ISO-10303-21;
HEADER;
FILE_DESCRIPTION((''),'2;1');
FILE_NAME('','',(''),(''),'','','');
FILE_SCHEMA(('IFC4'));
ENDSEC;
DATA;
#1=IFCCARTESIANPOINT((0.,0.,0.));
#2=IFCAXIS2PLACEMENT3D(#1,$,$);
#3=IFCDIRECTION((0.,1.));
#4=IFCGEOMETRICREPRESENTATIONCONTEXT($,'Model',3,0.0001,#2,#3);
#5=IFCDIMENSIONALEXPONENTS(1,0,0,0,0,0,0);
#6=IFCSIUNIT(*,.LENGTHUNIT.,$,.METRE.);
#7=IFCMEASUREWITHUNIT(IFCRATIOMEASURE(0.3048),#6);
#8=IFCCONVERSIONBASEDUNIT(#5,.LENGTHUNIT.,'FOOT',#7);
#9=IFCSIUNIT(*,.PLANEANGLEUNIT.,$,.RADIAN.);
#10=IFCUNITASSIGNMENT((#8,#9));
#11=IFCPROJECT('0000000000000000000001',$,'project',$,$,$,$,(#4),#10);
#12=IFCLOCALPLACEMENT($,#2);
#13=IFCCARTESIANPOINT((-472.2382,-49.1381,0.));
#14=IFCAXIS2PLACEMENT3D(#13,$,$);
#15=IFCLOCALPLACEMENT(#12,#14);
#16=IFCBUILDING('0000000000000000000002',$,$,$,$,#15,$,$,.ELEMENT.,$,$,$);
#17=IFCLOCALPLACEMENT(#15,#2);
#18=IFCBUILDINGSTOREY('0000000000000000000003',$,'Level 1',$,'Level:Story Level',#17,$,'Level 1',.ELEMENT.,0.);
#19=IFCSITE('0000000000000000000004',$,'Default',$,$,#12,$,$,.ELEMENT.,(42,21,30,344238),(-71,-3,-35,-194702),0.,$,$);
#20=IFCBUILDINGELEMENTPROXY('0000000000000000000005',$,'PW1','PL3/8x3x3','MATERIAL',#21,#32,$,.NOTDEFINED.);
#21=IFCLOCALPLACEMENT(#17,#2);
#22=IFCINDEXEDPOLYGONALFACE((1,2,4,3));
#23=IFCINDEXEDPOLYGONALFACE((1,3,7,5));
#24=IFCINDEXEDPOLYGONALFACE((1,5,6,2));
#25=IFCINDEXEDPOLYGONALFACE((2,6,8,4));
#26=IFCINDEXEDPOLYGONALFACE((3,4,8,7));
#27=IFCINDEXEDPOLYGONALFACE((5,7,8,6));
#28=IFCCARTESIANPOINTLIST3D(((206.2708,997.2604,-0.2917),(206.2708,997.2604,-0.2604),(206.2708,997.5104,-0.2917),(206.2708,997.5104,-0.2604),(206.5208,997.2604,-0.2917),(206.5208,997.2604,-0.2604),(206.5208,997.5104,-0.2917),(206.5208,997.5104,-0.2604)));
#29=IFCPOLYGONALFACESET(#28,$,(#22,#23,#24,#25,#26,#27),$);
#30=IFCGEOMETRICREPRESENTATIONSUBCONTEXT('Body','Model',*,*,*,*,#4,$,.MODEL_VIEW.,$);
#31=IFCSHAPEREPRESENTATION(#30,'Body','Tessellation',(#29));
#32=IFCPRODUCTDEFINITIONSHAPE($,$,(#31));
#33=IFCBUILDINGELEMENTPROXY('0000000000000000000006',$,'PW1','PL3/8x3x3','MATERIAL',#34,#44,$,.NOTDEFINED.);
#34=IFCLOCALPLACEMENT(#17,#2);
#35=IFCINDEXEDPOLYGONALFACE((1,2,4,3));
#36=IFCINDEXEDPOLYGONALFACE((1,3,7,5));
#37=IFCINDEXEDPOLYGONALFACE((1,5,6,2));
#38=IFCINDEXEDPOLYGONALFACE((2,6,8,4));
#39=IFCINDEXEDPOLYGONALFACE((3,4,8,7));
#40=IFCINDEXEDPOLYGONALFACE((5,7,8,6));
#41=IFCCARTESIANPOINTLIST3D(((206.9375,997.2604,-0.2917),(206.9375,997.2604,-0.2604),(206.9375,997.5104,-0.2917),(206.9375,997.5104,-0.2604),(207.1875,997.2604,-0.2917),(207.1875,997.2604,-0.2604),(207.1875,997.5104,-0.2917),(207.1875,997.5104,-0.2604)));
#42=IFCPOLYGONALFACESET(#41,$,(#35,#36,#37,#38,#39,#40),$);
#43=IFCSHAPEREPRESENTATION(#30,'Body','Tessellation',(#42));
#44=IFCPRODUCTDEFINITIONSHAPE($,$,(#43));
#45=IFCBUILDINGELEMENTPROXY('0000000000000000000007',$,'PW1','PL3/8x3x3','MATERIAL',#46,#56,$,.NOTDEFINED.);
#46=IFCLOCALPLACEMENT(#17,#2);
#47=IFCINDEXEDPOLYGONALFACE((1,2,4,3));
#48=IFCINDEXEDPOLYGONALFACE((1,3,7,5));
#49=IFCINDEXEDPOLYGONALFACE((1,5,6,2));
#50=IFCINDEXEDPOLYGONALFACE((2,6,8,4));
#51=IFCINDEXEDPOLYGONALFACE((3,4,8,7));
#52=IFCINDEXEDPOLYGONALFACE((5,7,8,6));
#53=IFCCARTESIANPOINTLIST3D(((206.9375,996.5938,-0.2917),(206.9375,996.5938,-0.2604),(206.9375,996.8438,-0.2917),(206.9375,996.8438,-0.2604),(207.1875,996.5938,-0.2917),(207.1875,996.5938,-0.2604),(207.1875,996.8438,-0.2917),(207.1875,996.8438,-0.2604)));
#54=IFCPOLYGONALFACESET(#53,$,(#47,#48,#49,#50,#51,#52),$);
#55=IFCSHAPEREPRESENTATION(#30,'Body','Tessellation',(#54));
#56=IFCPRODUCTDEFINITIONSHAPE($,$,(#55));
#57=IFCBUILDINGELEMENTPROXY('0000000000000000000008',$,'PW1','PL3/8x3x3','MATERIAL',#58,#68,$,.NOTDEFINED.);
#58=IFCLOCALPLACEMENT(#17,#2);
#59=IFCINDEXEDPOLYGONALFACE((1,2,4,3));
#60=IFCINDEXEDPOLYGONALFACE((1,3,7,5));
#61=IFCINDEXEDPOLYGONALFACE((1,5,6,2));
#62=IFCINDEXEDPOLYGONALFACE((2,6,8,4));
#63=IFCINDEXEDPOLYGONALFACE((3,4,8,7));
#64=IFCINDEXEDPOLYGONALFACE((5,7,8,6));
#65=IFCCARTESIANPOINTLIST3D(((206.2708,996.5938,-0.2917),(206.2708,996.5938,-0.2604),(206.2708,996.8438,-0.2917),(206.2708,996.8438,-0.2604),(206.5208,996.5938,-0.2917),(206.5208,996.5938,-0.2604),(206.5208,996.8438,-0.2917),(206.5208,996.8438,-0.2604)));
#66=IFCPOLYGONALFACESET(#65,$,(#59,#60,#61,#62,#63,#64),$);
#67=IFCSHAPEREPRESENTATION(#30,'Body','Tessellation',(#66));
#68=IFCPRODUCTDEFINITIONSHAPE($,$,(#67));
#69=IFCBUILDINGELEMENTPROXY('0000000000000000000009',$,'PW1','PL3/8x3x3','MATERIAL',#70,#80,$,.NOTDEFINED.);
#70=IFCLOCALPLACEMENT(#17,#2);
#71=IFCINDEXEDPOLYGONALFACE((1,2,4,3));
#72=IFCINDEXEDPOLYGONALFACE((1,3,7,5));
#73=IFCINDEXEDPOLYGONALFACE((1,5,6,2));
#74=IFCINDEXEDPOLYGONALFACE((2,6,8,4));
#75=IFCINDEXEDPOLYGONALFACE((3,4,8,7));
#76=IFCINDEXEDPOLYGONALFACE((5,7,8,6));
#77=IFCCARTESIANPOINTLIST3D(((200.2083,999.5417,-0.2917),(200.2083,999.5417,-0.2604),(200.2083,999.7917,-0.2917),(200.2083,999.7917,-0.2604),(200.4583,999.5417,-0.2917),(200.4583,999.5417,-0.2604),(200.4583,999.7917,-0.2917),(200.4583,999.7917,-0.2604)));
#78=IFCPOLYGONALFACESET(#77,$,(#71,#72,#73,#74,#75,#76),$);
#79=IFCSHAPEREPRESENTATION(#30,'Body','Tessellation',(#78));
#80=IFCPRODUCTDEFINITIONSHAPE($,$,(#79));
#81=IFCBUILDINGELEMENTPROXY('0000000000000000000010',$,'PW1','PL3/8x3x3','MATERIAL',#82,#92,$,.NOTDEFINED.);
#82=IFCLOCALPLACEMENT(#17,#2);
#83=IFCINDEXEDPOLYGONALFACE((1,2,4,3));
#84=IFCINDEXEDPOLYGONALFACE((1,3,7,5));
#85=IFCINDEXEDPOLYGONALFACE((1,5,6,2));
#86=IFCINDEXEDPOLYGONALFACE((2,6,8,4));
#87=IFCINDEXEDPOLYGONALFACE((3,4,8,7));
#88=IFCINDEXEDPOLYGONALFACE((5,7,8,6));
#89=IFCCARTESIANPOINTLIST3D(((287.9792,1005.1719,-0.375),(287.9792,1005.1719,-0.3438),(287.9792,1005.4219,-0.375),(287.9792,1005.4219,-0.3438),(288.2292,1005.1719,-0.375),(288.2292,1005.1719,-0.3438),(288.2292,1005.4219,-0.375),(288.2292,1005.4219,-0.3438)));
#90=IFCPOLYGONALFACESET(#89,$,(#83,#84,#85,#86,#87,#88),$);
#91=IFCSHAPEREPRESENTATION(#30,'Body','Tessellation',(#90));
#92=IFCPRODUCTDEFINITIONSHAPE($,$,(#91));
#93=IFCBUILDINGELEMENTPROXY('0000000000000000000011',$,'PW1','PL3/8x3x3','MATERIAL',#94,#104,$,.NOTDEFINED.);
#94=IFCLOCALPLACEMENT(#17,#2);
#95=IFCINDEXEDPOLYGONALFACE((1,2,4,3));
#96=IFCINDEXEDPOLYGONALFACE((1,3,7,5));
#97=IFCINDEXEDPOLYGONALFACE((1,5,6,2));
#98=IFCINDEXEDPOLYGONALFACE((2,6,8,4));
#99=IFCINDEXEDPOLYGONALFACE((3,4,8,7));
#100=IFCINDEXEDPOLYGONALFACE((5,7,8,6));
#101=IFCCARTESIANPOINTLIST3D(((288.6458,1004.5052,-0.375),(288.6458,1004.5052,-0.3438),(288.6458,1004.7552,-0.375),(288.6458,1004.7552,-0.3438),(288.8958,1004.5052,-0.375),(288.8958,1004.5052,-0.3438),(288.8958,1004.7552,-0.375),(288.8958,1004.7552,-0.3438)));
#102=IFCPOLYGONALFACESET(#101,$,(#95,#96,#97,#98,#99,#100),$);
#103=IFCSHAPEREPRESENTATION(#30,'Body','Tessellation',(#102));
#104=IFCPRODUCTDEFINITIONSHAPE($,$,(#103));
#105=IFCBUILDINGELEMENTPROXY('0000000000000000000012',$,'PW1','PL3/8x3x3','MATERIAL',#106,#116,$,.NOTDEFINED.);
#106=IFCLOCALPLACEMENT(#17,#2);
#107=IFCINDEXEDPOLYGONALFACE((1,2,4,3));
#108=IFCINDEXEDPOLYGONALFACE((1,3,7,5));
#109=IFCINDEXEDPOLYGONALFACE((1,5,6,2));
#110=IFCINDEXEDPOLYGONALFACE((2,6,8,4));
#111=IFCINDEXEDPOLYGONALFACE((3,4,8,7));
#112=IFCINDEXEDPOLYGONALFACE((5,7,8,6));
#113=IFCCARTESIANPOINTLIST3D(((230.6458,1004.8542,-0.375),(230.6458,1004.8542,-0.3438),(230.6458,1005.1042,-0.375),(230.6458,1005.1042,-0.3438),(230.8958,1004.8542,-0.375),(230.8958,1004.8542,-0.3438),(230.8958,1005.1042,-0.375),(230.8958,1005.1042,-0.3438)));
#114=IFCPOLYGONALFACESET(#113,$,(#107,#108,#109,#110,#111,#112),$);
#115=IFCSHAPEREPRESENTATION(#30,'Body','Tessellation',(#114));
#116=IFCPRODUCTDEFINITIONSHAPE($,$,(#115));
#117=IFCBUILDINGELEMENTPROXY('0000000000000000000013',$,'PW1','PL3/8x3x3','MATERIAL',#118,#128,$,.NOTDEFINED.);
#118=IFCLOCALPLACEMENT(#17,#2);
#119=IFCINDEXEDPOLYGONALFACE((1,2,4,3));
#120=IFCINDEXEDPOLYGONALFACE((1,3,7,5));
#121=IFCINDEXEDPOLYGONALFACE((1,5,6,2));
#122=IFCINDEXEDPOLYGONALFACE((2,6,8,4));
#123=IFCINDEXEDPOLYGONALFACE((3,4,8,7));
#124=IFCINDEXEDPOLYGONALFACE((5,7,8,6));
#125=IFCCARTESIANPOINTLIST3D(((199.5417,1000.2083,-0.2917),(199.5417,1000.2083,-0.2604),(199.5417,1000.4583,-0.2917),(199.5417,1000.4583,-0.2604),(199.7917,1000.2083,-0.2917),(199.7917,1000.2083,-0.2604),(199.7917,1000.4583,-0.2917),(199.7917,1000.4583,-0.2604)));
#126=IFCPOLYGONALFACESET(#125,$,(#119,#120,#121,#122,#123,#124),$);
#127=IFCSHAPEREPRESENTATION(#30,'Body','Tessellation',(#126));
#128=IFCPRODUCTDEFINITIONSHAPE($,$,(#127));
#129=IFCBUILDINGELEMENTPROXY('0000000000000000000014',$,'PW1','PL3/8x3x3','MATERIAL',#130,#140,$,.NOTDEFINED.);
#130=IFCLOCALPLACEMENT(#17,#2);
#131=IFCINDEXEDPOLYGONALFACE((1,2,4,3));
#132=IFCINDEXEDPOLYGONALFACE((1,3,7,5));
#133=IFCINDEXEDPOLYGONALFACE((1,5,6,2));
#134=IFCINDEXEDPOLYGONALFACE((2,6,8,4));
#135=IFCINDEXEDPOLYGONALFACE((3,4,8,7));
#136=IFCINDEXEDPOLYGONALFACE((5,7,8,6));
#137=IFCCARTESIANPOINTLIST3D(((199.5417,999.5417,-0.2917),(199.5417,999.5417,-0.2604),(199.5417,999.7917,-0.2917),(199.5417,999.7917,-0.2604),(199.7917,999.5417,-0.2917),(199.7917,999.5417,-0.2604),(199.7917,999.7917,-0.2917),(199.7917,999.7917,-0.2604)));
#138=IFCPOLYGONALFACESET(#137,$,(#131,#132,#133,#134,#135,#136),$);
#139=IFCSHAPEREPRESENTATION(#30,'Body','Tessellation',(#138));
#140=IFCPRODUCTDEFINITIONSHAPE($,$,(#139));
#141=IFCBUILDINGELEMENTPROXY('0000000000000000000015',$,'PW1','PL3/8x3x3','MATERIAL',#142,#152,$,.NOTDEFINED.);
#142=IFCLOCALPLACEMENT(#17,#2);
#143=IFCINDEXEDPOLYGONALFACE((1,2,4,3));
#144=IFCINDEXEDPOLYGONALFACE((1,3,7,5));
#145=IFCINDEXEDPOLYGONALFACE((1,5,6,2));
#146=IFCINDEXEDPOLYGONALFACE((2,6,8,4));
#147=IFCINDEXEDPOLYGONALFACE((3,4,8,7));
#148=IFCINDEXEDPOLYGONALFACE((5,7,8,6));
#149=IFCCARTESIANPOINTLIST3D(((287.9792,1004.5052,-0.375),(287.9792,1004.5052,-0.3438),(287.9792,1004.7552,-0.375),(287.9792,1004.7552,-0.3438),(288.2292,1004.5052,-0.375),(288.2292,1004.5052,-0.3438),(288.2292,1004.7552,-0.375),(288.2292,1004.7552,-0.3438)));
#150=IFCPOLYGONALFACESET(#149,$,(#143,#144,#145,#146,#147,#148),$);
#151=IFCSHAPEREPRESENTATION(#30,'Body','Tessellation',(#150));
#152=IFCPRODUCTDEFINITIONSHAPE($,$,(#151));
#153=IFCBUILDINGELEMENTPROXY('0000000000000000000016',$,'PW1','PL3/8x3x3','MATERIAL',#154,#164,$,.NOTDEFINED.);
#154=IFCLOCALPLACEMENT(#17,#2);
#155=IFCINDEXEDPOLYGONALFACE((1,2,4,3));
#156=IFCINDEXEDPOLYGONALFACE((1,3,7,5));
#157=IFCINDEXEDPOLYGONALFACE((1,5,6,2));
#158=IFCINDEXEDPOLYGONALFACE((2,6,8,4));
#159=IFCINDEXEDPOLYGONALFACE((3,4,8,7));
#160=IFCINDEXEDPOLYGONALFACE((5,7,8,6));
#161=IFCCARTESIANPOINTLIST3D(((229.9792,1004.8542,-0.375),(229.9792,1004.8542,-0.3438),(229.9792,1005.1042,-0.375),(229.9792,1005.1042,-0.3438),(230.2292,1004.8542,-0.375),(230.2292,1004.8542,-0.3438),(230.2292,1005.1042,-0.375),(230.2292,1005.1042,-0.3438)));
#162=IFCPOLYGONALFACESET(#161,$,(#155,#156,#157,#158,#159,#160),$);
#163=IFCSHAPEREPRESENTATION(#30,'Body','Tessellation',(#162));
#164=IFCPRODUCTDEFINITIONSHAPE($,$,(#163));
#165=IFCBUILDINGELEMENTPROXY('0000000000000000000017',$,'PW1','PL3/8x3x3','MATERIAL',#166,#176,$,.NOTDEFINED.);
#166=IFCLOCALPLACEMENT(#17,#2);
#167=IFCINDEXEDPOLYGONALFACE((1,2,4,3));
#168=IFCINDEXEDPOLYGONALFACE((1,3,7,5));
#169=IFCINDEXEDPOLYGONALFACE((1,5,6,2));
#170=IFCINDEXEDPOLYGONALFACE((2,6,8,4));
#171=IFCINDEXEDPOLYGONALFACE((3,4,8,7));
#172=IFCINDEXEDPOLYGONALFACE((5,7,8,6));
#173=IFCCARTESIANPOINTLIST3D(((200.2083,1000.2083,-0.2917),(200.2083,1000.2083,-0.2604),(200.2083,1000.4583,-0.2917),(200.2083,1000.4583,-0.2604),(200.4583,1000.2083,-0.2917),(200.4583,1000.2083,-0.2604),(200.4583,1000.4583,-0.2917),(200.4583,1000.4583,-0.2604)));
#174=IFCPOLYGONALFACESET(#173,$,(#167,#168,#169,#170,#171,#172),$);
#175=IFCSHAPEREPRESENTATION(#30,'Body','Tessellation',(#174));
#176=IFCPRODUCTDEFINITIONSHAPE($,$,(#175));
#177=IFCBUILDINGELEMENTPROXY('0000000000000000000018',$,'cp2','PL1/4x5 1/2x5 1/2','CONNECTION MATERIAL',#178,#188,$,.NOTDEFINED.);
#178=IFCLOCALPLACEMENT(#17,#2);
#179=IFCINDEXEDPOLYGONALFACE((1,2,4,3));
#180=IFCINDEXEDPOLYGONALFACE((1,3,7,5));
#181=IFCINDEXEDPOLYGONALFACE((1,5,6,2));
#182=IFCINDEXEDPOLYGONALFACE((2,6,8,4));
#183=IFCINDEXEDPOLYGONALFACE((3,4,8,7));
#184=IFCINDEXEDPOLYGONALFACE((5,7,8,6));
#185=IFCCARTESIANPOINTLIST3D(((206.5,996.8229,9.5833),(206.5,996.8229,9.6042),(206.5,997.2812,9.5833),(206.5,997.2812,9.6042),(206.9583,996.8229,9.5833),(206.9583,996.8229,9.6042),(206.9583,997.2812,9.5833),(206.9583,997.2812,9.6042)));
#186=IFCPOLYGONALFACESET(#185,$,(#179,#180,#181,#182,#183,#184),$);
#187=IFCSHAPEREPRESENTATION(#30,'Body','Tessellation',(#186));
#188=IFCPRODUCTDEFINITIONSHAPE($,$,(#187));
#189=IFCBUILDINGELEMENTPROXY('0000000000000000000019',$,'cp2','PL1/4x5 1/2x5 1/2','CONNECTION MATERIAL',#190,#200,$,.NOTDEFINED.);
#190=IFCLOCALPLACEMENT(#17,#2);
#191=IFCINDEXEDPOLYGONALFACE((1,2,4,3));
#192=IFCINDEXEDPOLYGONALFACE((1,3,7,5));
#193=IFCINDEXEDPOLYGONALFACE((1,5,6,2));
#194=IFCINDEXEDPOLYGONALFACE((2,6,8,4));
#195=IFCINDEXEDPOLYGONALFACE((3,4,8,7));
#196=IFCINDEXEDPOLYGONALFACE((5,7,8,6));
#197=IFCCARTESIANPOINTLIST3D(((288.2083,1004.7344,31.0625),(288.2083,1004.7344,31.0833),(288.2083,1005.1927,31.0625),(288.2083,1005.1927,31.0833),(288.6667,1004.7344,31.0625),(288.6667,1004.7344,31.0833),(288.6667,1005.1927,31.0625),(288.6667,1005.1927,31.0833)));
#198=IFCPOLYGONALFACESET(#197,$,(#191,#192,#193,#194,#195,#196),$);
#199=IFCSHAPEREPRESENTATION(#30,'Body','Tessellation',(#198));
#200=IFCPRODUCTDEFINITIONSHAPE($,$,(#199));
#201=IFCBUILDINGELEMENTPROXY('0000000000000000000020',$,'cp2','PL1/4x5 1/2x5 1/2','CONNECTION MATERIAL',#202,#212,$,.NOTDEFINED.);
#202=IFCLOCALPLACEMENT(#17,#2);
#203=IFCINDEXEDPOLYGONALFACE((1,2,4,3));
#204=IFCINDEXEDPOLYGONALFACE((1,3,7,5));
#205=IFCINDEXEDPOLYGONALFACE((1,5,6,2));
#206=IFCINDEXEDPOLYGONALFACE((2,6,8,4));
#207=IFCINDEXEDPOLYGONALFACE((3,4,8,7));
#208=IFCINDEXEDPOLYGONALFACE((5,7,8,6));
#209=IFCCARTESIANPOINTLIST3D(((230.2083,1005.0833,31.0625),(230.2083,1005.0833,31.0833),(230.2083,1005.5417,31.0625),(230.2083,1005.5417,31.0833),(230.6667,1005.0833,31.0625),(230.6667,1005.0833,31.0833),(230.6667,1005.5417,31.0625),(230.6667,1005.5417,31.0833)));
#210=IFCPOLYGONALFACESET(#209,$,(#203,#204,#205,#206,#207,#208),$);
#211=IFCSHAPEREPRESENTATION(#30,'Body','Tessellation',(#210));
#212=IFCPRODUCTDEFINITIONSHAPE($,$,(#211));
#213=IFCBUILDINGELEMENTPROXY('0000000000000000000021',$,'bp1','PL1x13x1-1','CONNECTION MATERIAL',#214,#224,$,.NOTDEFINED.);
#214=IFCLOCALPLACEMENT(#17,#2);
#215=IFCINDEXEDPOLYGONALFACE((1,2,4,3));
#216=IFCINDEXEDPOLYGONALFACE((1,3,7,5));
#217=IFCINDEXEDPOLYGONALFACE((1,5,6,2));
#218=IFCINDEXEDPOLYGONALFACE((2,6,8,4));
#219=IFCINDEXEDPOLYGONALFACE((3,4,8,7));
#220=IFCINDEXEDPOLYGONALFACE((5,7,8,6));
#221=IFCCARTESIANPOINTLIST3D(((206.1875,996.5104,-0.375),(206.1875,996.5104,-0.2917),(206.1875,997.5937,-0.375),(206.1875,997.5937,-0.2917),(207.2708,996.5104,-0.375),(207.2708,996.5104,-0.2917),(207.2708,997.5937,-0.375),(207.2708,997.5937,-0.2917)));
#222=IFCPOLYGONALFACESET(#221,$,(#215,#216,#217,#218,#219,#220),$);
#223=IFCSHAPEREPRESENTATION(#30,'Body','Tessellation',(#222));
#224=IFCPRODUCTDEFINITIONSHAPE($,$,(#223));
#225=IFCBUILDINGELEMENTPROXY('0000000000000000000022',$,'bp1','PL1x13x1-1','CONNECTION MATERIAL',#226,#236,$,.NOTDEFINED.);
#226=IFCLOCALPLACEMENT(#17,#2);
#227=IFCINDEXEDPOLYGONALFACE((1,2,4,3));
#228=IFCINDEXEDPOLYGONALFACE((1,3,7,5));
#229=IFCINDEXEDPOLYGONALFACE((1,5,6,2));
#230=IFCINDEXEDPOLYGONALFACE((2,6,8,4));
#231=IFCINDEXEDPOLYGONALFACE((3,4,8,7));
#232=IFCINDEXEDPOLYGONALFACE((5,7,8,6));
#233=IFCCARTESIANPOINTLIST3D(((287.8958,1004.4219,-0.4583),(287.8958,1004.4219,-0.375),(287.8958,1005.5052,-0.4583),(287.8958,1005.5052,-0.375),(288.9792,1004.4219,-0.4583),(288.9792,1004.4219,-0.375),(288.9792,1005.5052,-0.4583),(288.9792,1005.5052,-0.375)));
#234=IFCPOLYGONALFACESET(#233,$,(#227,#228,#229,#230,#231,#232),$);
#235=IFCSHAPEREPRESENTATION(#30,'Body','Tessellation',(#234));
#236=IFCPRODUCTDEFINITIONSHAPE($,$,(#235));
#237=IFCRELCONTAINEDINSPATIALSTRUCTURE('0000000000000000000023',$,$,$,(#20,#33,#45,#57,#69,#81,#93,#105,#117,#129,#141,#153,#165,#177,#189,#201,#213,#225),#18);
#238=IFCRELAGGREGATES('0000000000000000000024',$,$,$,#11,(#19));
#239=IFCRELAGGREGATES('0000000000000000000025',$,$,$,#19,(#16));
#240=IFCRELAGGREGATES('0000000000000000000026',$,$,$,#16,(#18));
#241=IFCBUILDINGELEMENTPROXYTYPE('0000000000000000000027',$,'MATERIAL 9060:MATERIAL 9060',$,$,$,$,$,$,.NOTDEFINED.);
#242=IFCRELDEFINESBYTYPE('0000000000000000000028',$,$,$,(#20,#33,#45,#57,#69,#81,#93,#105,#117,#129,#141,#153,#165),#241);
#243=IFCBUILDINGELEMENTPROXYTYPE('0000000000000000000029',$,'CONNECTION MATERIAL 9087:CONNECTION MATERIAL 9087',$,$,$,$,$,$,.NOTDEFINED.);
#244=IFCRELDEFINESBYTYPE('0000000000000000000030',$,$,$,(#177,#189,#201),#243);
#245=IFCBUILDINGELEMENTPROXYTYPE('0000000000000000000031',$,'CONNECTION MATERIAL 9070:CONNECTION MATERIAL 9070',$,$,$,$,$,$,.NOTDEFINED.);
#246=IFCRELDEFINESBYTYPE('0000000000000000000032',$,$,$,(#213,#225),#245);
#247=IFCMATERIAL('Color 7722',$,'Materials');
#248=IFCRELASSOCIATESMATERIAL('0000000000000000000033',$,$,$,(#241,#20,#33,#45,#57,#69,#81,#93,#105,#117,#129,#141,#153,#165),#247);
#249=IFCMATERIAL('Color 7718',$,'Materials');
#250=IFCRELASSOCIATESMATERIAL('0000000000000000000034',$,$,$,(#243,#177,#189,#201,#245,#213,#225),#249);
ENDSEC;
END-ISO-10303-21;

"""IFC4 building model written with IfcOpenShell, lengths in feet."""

from ifc_helpers import new_model, entity, si_unit, converted_unit, direction, frame, origin, origin_2d_with_axis, place, context, subcontext, project, spatial, rectangle, extrude, source, transform, mapped, material, type_object, type_shapes, element, save


model = new_model("IFC4")

# Units and contexts
model_context = context("Model", 3, precision=0.0001, world=origin(), true_north=direction((0.0, 1.0)))
body_context = subcontext(model_context, "Body", "Model", "MODEL_VIEW")
ifc_project = project(units=[converted_unit("LENGTHUNIT", "FOOT", entity("IfcRatioMeasure", 0.3048), si_unit("LENGTHUNIT", "METRE"), dimensions=[1, 0, 0, 0, 0, 0, 0]), si_unit("PLANEANGLEUNIT", "RADIAN")], contexts=[model_context])

# Site, building, storey
site_placement = place(None, origin())
site = spatial("IfcSite", under=ifc_project, at=site_placement, Name="Default", CompositionType="ELEMENT", RefLatitude=(42, 21, 30, 344238), RefLongitude=(-71, -3, -35, -194702), RefElevation=0.0)
building_placement = place(site_placement, frame((-472.2382, -49.1381, 0.0)))
building = spatial("IfcBuilding", under=site, at=building_placement, CompositionType="ELEMENT")
storey_placement = place(building_placement, origin())
storey = spatial("IfcBuildingStorey", under=building, at=storey_placement, Name="Level 1", ObjectType="Level:Story Level", LongName="Level 1", CompositionType="ELEMENT", Elevation=0.0)

# Building element proxies
ifc_material_1 = material(Name="Color 7722", Category="Materials")
building_element_proxy_type_1 = type_object("IfcBuildingElementProxyType", Name="MATERIAL 9060:MATERIAL 9060", PredefinedType="NOTDEFINED", material=ifc_material_1)
shared_shape_1 = source(origin(), body_context, "Body", "SweptSolid", [
    extrude(rectangle(XDim=0.25, YDim=0.25, at=origin_2d_with_axis()), frame((0.125, -0.125, 0.0)), (0.0, 0.0, 1.0), 0.0312),
])
type_shapes(building_element_proxy_type_1, [shared_shape_1])
for number, where, z_axis, x_axis, name in (
    (1, (206.2708, 997.5104, -0.2604), (0.0, 0.0, -1.0), (0.0, -1.0, 0.0), "PW1"),
    (2, (206.9375, 997.5104, -0.2604), (0.0, 0.0, -1.0), (0.0, -1.0, 0.0), "PW1"),
    (3, (206.9375, 996.8438, -0.2604), (0.0, 0.0, -1.0), (0.0, -1.0, 0.0), "PW1"),
    (4, (206.2708, 996.8438, -0.2604), (0.0, 0.0, -1.0), (0.0, -1.0, 0.0), "PW1"),
    (5, (200.2083, 999.7917, -0.2604), (0.0, 0.0, -1.0), (0.0, -1.0, 0.0), "PW1"),
    (6, (287.9792, 1005.4219, -0.3438), (0.0, 0.0, -1.0), (0.0, -1.0, 0.0), "PW1"),
    (7, (288.6458, 1004.7552, -0.3438), (0.0, 0.0, -1.0), (0.0, -1.0, 0.0), "PW1"),
    (8, (230.6458, 1005.1042, -0.3438), (0.0, 0.0, -1.0), (0.0, -1.0, 0.0), "PW1"),
    (9, (199.5417, 1000.4583, -0.2604), (0.0, 0.0, -1.0), (0.0, -1.0, 0.0), "PW1"),
    (10, (199.5417, 999.7917, -0.2604), (0.0, 0.0, -1.0), (0.0, -1.0, 0.0), "PW1"),
    (11, (287.9792, 1004.7552, -0.3438), (0.0, 0.0, -1.0), (0.0, -1.0, 0.0), "PW1"),
    (12, (229.9792, 1005.1042, -0.3438), (0.0, 0.0, -1.0), (0.0, -1.0, 0.0), "PW1"),
    (13, (200.2083, 1000.4583, -0.2604), (0.0, 0.0, -1.0), (0.0, -1.0, 0.0), "PW1"),
):
    element("IfcBuildingElementProxy", number, at=place(building_placement, frame(where, z_axis=z_axis, x_axis=x_axis)), inside=storey, type_object=building_element_proxy_type_1, material=ifc_material_1, Name=name, Description="PL3/8x3x3", ObjectType="MATERIAL", PredefinedType="NOTDEFINED", context=body_context, shape_type="MappedRepresentation", body=[
        mapped(shared_shape_1, transform((0.0, 0.0, 0.0), scale=1.0)),
    ])
ifc_material_2 = material(Name="Color 7718", Category="Materials")
building_element_proxy_type_2 = type_object("IfcBuildingElementProxyType", Name="CONNECTION MATERIAL 9087:CONNECTION MATERIAL 9087", PredefinedType="NOTDEFINED", material=ifc_material_2)
shared_shape_2 = source(origin(), body_context, "Body", "SweptSolid", [
    extrude(rectangle(XDim=0.4583, YDim=0.4583, at=origin_2d_with_axis()), frame((0.0, 0.0, -0.0208)), (0.0, 0.0, 1.0), 0.0208),
])
type_shapes(building_element_proxy_type_2, [shared_shape_2])
for number, where, z_axis, x_axis, name in (
    (14, (206.7292, 997.0521, 9.5833), (0.0, 0.0, -1.0), (1.0, 0.0, 0.0), "cp2"),
    (15, (288.4375, 1004.9635, 31.0625), (0.0, 0.0, -1.0), (1.0, 0.0, 0.0), "cp2"),
    (16, (230.4375, 1005.3125, 31.0625), (0.0, 0.0, -1.0), (1.0, 0.0, 0.0), "cp2"),
):
    element("IfcBuildingElementProxy", number, at=place(building_placement, frame(where, z_axis=z_axis, x_axis=x_axis)), inside=storey, type_object=building_element_proxy_type_2, material=ifc_material_2, Name=name, Description="PL1/4x5 1/2x5 1/2", ObjectType="CONNECTION MATERIAL", PredefinedType="NOTDEFINED", context=body_context, shape_type="MappedRepresentation", body=[
        mapped(shared_shape_2, transform((0.0, 0.0, 0.0), scale=1.0)),
    ])
building_element_proxy_type_3 = type_object("IfcBuildingElementProxyType", Name="CONNECTION MATERIAL 9070:CONNECTION MATERIAL 9070", PredefinedType="NOTDEFINED", material=ifc_material_2)
shared_shape_3 = source(origin(), body_context, "Body", "SweptSolid", [
    extrude(rectangle(XDim=1.0833, YDim=1.0833, at=origin_2d_with_axis()), frame((0.0, 0.0, -0.0833)), (0.0, 0.0, 1.0), 0.0833),
])
type_shapes(building_element_proxy_type_3, [shared_shape_3])
for number, where, name in (
    (17, (206.7292, 997.0521, -0.2917), "bp1"),
    (18, (288.4375, 1004.9635, -0.375), "bp1"),
):
    element("IfcBuildingElementProxy", number, at=place(building_placement, frame(where)), inside=storey, type_object=building_element_proxy_type_3, material=ifc_material_2, Name=name, Description="PL1x13x1-1", ObjectType="CONNECTION MATERIAL", PredefinedType="NOTDEFINED", context=body_context, shape_type="MappedRepresentation", body=[
        mapped(shared_shape_3, transform((0.0, 0.0, 0.0), scale=1.0)),
    ])

save(model, "model.ifc")
